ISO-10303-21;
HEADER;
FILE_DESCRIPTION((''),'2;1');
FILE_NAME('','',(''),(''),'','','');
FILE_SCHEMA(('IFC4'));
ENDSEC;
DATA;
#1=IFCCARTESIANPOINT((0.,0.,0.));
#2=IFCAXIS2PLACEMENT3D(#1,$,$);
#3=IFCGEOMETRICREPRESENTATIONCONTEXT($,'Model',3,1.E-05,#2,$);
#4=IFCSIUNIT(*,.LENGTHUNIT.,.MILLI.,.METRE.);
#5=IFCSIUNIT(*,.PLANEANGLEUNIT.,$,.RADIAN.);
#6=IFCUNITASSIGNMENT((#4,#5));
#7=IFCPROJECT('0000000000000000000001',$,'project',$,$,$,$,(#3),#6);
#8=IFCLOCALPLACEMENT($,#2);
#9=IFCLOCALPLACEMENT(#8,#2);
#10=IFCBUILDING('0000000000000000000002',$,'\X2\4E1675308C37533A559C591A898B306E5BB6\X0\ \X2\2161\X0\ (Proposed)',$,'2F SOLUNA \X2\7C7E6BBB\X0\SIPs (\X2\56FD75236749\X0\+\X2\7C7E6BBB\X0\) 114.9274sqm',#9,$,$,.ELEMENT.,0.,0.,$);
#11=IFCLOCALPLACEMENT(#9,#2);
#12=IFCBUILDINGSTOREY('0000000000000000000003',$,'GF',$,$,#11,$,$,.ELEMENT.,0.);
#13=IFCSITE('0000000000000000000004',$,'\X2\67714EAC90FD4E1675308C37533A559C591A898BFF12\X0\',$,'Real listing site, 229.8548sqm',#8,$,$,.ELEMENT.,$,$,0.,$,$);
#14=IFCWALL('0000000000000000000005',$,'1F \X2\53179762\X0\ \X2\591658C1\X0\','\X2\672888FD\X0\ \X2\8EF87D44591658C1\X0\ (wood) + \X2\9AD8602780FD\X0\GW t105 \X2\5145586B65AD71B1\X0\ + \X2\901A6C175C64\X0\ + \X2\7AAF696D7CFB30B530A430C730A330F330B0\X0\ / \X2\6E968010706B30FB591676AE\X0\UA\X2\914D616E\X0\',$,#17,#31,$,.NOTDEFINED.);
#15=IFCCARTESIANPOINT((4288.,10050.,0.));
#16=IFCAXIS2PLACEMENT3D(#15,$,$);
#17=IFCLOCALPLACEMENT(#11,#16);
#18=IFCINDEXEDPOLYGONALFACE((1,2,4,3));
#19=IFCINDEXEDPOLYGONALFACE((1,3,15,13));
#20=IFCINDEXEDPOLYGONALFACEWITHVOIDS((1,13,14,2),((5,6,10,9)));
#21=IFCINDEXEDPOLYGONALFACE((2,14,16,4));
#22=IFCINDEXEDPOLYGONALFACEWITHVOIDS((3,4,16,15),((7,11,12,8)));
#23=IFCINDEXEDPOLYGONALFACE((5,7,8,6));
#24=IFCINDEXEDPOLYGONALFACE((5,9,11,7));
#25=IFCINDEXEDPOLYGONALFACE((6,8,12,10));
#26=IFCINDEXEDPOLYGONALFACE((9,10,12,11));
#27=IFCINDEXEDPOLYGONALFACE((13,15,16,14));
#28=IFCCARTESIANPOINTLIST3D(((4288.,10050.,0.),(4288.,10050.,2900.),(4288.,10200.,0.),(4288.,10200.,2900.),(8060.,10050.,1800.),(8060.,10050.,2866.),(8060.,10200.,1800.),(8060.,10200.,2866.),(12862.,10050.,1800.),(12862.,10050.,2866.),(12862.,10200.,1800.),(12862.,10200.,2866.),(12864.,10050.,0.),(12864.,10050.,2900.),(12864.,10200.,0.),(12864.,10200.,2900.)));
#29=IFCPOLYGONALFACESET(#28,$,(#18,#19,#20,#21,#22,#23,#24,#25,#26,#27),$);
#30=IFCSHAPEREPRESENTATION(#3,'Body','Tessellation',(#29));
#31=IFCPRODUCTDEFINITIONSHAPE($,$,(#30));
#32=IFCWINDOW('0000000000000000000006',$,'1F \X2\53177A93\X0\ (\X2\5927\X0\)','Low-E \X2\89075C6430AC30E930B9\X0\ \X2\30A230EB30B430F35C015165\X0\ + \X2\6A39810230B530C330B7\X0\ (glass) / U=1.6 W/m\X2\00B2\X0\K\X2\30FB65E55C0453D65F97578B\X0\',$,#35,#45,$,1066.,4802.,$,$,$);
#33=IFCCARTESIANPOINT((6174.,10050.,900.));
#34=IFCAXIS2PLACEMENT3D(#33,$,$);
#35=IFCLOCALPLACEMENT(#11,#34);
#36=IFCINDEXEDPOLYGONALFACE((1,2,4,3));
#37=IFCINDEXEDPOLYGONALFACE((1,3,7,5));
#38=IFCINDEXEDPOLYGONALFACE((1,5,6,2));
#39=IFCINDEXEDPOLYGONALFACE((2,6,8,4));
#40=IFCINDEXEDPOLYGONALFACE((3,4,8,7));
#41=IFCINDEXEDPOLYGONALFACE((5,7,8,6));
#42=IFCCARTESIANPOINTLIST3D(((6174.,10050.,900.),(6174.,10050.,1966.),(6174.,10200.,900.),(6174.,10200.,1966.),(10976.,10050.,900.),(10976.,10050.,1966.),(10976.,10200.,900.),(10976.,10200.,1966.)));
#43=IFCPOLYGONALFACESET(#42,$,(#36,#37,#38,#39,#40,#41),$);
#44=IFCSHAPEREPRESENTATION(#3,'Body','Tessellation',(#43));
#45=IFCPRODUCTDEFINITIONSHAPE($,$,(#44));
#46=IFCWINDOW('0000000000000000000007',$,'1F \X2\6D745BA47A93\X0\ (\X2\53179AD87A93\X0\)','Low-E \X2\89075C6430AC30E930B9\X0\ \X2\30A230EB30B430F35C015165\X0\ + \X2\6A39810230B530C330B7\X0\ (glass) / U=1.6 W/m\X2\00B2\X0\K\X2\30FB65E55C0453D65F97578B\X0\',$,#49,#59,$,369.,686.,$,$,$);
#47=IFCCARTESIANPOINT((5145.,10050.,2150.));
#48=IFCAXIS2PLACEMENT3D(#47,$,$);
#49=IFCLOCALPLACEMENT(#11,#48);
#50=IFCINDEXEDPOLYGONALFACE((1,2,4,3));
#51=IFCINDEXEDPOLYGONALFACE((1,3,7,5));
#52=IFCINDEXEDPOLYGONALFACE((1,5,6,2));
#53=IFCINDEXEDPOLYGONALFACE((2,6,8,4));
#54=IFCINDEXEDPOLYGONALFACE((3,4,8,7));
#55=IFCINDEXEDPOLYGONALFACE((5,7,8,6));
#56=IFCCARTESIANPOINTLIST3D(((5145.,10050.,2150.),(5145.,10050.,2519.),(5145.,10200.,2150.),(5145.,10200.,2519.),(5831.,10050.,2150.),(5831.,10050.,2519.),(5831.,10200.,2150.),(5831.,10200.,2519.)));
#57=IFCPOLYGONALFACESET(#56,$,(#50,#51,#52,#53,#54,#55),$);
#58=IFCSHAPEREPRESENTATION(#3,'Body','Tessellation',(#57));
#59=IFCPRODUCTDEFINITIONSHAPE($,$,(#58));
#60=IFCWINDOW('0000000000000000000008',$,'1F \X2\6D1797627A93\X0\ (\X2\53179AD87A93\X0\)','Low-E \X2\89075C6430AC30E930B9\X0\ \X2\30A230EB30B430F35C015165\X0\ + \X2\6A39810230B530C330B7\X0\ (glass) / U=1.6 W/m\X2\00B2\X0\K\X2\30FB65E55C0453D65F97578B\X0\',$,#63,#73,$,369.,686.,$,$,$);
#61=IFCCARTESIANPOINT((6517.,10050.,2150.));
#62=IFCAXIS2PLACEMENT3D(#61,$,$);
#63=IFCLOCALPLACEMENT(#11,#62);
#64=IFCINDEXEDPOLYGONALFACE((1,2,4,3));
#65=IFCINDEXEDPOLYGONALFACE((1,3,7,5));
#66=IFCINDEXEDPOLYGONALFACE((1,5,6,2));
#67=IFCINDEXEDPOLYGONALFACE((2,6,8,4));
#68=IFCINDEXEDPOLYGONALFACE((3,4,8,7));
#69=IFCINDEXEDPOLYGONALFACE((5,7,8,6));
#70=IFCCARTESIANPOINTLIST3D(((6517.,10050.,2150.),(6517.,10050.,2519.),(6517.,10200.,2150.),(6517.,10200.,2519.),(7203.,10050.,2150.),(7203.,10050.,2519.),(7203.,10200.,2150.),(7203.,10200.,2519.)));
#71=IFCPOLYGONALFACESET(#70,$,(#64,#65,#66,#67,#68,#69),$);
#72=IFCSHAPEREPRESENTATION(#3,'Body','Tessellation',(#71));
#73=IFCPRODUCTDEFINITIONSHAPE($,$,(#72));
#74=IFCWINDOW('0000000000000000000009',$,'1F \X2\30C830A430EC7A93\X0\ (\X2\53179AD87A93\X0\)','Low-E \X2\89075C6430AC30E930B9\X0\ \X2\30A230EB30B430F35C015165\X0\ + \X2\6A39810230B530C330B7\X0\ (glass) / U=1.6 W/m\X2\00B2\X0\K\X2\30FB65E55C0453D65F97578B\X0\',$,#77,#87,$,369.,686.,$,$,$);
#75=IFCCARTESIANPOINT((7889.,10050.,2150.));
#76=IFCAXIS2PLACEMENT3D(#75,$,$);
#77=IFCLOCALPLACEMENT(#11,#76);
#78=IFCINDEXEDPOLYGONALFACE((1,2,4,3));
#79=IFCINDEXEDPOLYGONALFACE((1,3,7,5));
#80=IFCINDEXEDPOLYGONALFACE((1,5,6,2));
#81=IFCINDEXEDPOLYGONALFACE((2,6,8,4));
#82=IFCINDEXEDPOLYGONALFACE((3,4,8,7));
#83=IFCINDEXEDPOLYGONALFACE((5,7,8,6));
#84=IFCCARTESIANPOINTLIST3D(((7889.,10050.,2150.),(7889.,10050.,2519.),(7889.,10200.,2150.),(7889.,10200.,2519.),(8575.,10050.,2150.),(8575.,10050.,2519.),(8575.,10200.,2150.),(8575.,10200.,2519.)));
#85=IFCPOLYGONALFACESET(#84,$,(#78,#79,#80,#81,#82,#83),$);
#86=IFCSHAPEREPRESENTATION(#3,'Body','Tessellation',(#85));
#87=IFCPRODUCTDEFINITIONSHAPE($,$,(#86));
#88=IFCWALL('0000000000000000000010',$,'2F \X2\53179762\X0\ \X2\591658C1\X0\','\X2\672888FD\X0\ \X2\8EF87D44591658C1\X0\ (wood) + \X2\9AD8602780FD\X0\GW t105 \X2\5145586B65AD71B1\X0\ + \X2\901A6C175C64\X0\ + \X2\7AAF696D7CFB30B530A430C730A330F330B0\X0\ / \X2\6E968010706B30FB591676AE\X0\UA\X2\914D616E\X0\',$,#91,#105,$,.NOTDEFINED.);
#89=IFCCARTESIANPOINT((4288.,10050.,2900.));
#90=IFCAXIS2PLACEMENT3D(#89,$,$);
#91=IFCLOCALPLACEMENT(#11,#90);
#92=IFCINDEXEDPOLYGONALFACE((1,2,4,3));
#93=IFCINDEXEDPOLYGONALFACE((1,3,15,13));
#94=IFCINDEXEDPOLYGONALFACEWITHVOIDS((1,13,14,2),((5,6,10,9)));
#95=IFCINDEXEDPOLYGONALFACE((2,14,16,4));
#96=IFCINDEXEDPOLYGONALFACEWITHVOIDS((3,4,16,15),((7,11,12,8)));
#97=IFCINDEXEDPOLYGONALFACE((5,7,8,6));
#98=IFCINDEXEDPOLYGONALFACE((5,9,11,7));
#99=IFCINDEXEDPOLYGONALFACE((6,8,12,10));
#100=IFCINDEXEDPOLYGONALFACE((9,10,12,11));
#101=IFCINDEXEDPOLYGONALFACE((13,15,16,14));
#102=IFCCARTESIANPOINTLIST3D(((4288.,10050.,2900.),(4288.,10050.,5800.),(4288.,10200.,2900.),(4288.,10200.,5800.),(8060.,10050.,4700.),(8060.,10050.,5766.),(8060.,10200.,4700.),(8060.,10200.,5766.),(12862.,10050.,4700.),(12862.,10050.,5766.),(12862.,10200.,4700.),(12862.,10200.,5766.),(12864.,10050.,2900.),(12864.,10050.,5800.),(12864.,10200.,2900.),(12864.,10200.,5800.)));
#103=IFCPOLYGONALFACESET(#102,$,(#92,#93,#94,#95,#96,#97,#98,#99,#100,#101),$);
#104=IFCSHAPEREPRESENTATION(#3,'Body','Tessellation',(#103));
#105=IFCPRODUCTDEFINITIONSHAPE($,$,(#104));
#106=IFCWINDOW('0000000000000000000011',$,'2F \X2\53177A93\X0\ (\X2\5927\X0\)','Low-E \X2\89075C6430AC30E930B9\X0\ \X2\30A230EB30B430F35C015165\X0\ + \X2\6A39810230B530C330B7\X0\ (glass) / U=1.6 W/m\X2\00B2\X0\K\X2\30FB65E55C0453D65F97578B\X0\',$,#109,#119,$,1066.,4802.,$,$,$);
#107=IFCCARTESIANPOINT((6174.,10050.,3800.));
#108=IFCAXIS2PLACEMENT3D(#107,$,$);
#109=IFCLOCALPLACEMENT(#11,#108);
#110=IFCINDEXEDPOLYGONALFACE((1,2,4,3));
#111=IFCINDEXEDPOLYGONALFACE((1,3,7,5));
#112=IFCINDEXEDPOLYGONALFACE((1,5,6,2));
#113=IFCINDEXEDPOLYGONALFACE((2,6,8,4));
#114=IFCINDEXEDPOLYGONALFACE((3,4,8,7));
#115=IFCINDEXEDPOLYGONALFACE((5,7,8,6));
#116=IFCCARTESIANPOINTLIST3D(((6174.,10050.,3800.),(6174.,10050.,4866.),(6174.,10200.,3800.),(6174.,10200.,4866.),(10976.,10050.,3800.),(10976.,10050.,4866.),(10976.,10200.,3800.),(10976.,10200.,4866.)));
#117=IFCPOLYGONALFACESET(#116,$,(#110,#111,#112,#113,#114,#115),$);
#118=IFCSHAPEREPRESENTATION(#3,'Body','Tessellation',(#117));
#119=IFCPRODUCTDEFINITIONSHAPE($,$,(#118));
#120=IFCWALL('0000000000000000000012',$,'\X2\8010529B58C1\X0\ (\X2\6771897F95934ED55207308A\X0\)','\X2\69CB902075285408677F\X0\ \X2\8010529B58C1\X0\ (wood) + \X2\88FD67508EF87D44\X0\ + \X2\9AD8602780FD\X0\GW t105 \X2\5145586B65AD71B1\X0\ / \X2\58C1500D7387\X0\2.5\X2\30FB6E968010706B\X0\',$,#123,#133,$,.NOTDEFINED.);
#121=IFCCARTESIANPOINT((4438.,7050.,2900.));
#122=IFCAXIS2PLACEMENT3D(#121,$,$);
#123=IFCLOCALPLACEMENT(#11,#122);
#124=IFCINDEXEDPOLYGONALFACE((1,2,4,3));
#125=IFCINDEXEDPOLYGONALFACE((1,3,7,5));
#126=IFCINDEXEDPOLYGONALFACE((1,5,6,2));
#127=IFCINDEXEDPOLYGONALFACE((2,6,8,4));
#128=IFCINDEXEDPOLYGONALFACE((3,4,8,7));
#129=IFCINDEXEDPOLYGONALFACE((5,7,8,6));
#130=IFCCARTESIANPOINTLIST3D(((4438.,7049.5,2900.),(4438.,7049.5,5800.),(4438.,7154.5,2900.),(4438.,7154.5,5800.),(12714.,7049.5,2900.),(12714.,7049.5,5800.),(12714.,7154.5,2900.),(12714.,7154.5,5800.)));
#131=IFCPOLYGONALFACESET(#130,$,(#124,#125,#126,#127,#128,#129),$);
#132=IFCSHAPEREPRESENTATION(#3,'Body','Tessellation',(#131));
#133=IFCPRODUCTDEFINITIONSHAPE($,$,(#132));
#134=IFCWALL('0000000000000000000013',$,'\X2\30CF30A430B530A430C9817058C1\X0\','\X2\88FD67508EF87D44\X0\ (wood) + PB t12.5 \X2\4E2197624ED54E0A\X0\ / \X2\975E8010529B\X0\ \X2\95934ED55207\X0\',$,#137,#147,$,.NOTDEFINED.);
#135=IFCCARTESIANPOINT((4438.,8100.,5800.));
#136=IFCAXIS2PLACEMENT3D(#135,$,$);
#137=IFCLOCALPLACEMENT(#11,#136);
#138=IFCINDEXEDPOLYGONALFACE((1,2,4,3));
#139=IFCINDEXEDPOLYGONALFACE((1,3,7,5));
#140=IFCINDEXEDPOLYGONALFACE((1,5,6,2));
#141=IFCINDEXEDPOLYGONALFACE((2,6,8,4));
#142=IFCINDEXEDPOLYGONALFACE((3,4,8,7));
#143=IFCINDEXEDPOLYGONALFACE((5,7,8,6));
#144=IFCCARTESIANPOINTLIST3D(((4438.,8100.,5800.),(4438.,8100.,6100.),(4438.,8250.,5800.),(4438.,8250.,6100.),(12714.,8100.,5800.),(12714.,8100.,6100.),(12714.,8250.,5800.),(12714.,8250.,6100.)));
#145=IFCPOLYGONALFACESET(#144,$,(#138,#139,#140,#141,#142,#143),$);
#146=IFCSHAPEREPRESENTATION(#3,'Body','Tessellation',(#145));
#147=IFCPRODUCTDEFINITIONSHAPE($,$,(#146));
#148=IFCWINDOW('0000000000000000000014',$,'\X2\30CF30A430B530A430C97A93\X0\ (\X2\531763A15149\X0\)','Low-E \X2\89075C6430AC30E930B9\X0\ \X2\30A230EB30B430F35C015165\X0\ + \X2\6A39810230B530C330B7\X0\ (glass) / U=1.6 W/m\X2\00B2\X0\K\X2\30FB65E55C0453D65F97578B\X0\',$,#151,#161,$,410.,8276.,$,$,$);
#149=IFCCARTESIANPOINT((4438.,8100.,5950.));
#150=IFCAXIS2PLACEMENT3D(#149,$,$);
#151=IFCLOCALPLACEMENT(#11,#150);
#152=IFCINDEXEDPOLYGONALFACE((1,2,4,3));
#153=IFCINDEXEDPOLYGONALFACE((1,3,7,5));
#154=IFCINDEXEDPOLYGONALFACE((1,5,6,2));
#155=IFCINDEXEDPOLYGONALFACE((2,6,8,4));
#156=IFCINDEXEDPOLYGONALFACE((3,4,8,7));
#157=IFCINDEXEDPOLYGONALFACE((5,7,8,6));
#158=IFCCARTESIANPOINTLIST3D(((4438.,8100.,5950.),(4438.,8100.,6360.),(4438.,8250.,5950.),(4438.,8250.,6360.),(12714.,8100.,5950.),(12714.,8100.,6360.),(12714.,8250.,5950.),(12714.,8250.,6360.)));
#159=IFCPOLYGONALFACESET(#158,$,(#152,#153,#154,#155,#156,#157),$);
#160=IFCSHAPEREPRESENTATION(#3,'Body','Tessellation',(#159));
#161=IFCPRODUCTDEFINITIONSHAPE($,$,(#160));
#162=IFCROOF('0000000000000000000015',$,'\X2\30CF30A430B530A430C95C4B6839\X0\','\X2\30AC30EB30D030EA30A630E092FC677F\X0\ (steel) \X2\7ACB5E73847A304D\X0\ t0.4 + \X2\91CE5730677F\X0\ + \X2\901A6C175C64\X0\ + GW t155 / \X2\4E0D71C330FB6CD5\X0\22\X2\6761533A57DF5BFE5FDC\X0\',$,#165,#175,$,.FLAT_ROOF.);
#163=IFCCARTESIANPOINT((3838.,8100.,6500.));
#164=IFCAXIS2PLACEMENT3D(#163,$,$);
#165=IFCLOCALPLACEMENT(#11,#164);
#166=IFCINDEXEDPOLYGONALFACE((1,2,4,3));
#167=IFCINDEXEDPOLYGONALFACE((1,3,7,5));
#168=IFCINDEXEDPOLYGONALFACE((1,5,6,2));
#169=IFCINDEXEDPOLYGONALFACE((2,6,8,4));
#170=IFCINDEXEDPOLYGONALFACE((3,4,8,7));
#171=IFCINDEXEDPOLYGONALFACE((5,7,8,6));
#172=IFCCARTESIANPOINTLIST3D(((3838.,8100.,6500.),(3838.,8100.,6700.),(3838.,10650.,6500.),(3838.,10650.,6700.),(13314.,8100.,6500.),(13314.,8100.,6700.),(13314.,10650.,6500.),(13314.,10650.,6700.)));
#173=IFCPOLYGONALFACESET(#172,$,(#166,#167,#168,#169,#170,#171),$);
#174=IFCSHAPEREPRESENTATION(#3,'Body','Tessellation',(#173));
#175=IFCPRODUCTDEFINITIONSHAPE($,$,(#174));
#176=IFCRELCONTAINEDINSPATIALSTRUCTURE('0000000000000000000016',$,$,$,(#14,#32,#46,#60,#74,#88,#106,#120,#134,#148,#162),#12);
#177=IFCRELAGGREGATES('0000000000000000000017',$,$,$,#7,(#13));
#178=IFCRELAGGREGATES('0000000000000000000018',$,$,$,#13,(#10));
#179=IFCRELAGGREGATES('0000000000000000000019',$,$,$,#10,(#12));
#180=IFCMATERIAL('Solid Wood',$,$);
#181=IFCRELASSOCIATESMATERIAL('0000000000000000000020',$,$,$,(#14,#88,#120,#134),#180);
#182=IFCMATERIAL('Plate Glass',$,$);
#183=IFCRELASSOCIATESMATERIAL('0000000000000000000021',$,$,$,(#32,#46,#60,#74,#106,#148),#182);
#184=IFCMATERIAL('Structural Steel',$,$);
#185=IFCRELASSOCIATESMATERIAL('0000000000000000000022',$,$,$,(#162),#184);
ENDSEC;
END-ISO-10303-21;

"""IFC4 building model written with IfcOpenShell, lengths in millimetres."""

from ifc_helpers import new_model, si_unit, frame, frame_2d, origin, place, context, project, spatial, rectangle, extrude, material, element, fill, save


model = new_model("IFC4")

# Units and contexts
model_context = context("Model", 3, precision=1e-05, world=origin())
ifc_project = project(units=[si_unit("LENGTHUNIT", "METRE", prefix="MILLI"), si_unit("PLANEANGLEUNIT", "RADIAN")], contexts=[model_context])

# Site, building, storey
site_placement = place(None, origin())
site = spatial("IfcSite", under=ifc_project, at=site_placement, Name="東京都世田谷区喜多見２", ObjectType="Real listing site, 229.8548sqm", CompositionType="ELEMENT", RefElevation=0.0)
building_placement = place(site_placement, origin())
building = spatial("IfcBuilding", under=site, at=building_placement, Name="世田谷区喜多見の家 Ⅱ (Proposed)", ObjectType="2F SOLUNA 籾殻SIPs (国産杉+籾殻) 114.9274sqm", CompositionType="ELEMENT", ElevationOfRefHeight=0.0, ElevationOfTerrain=0.0)
storey_placement = place(building_placement, origin())
storey = spatial("IfcBuildingStorey", under=building, at=storey_placement, Name="GF", CompositionType="ELEMENT", Elevation=0.0)

# Wall, openings, windows
ifc_material_1 = material(Name="Solid Wood")
wall_1_placement = place(storey_placement, frame((4288.0, 10050.0, 0.0)))
wall_1 = element("IfcWall", 1, at=wall_1_placement, inside=storey, material=ifc_material_1, Name="1F 北面 外壁", Description="木製 軸組外壁 (wood) + 高性能GW t105 充填断熱 + 通気層 + 窯業系サイディング / 準耐火・外皮UA配慮", PredefinedType="NOTDEFINED", context=model_context, shape_type="SweptSolid", body=[
    extrude(rectangle(XDim=8576.0, YDim=150.0, at=frame_2d((4288.0, 75.0))), frame((4288.0, 10050.0, 0.0)), (0.0, 0.0, 1.0), 2900.0),
])
opening_1_placement = place(storey_placement, frame((6174.0, 10050.0, 900.0)))
opening_1 = element("IfcOpeningElement", 2, at=opening_1_placement, cuts=wall_1, PredefinedType="NOTDEFINED", context=model_context, shape_type="SweptSolid", body=[
    extrude(rectangle(XDim=4802.0, YDim=150.0, at=frame_2d((2401.0, 75.0))), frame((6174.0, 10050.0, 900.0)), (0.0, 0.0, 1.0), 1066.0),
])
opening_2_placement = place(storey_placement, frame((5145.0, 10050.0, 2150.0)))
opening_2 = element("IfcOpeningElement", 3, at=opening_2_placement, cuts=wall_1, PredefinedType="NOTDEFINED", context=model_context, shape_type="SweptSolid", body=[
    extrude(rectangle(XDim=686.0, YDim=150.0, at=frame_2d((343.0, 75.0))), frame((5145.0, 10050.0, 2150.0)), (0.0, 0.0, 1.0), 369.0),
])
opening_3_placement = place(storey_placement, frame((6517.0, 10050.0, 2150.0)))
opening_3 = element("IfcOpeningElement", 4, at=opening_3_placement, cuts=wall_1, PredefinedType="NOTDEFINED", context=model_context, shape_type="SweptSolid", body=[
    extrude(rectangle(XDim=686.0, YDim=150.0, at=frame_2d((343.0, 75.0))), frame((6517.0, 10050.0, 2150.0)), (0.0, 0.0, 1.0), 369.0),
])
opening_4_placement = place(storey_placement, frame((7889.0, 10050.0, 2150.0)))
opening_4 = element("IfcOpeningElement", 5, at=opening_4_placement, cuts=wall_1, PredefinedType="NOTDEFINED", context=model_context, shape_type="SweptSolid", body=[
    extrude(rectangle(XDim=686.0, YDim=150.0, at=frame_2d((343.0, 75.0))), frame((7889.0, 10050.0, 2150.0)), (0.0, 0.0, 1.0), 369.0),
])
ifc_material_2 = material(Name="Plate Glass")
window_1_placement = place(storey_placement, frame((6174.0, 10050.0, 900.0)))
window_1 = element("IfcWindow", 6, at=window_1_placement, inside=storey, material=ifc_material_2, Name="1F 北窓 (大)", Description="Low-E 複層ガラス アルゴン封入 + 樹脂サッシ (glass) / U=1.6 W/m²K・日射取得型", OverallHeight=1066.0, OverallWidth=4802.0, context=model_context, shape_type="SweptSolid", body=[
    extrude(rectangle(XDim=4802.0, YDim=150.0, at=frame_2d((2401.0, 75.0))), frame((6174.0, 10050.0, 900.0)), (0.0, 0.0, 1.0), 1066.0),
])
fill(opening_1, window_1)
window_2_placement = place(storey_placement, frame((5145.0, 10050.0, 2150.0)))
window_2 = element("IfcWindow", 7, at=window_2_placement, inside=storey, material=ifc_material_2, Name="1F 浴室窓 (北高窓)", Description="Low-E 複層ガラス アルゴン封入 + 樹脂サッシ (glass) / U=1.6 W/m²K・日射取得型", OverallHeight=369.0, OverallWidth=686.0, context=model_context, shape_type="SweptSolid", body=[
    extrude(rectangle(XDim=686.0, YDim=150.0, at=frame_2d((343.0, 75.0))), frame((5145.0, 10050.0, 2150.0)), (0.0, 0.0, 1.0), 369.0),
])
fill(opening_2, window_2)
window_3_placement = place(storey_placement, frame((6517.0, 10050.0, 2150.0)))
window_3 = element("IfcWindow", 8, at=window_3_placement, inside=storey, material=ifc_material_2, Name="1F 洗面窓 (北高窓)", Description="Low-E 複層ガラス アルゴン封入 + 樹脂サッシ (glass) / U=1.6 W/m²K・日射取得型", OverallHeight=369.0, OverallWidth=686.0, context=model_context, shape_type="SweptSolid", body=[
    extrude(rectangle(XDim=686.0, YDim=150.0, at=frame_2d((343.0, 75.0))), frame((6517.0, 10050.0, 2150.0)), (0.0, 0.0, 1.0), 369.0),
])
fill(opening_3, window_3)
window_4_placement = place(storey_placement, frame((7889.0, 10050.0, 2150.0)))
window_4 = element("IfcWindow", 9, at=window_4_placement, inside=storey, material=ifc_material_2, Name="1F トイレ窓 (北高窓)", Description="Low-E 複層ガラス アルゴン封入 + 樹脂サッシ (glass) / U=1.6 W/m²K・日射取得型", OverallHeight=369.0, OverallWidth=686.0, context=model_context, shape_type="SweptSolid", body=[
    extrude(rectangle(XDim=686.0, YDim=150.0, at=frame_2d((343.0, 75.0))), frame((7889.0, 10050.0, 2150.0)), (0.0, 0.0, 1.0), 369.0),
])
fill(opening_4, window_4)

# Wall, opening, window
wall_2_placement = place(storey_placement, frame((4288.0, 10050.0, 2900.0)))
wall_2 = element("IfcWall", 10, at=wall_2_placement, inside=storey, material=ifc_material_1, Name="2F 北面 外壁", Description="木製 軸組外壁 (wood) + 高性能GW t105 充填断熱 + 通気層 + 窯業系サイディング / 準耐火・外皮UA配慮", PredefinedType="NOTDEFINED", context=model_context, shape_type="SweptSolid", body=[
    extrude(rectangle(XDim=8576.0, YDim=150.0, at=frame_2d((4288.0, 75.0))), frame((4288.0, 10050.0, 2900.0)), (0.0, 0.0, 1.0), 2900.0),
])
opening_5_placement = place(storey_placement, frame((6174.0, 10050.0, 3800.0)))
opening_5 = element("IfcOpeningElement", 11, at=opening_5_placement, cuts=wall_2, PredefinedType="NOTDEFINED", context=model_context, shape_type="SweptSolid", body=[
    extrude(rectangle(XDim=4802.0, YDim=150.0, at=frame_2d((2401.0, 75.0))), frame((6174.0, 10050.0, 3800.0)), (0.0, 0.0, 1.0), 1066.0),
])
window_5_placement = place(storey_placement, frame((6174.0, 10050.0, 3800.0)))
window_5 = element("IfcWindow", 12, at=window_5_placement, inside=storey, material=ifc_material_2, Name="2F 北窓 (大)", Description="Low-E 複層ガラス アルゴン封入 + 樹脂サッシ (glass) / U=1.6 W/m²K・日射取得型", OverallHeight=1066.0, OverallWidth=4802.0, context=model_context, shape_type="SweptSolid", body=[
    extrude(rectangle(XDim=4802.0, YDim=150.0, at=frame_2d((2401.0, 75.0))), frame((6174.0, 10050.0, 3800.0)), (0.0, 0.0, 1.0), 1066.0),
])
fill(opening_5, window_5)

# Wall
wall_3_placement = place(storey_placement, frame((4438.0, 7050.0, 2900.0)))
element("IfcWall", 13, at=wall_3_placement, inside=storey, material=ifc_material_1, Name="耐力壁 (東西間仕切り)", Description="構造用合板 耐力壁 (wood) + 製材軸組 + 高性能GW t105 充填断熱 / 壁倍率2.5・準耐火", PredefinedType="NOTDEFINED", context=model_context, shape_type="SweptSolid", body=[
    extrude(rectangle(XDim=8276.0, YDim=105.0, at=frame_2d((4138.0, 52.0))), frame((4438.0, 7050.0, 2900.0)), (0.0, 0.0, 1.0), 2900.0),
])

# Wall, opening, window
wall_4_placement = place(storey_placement, frame((4438.0, 8100.0, 5800.0)))
wall_4 = element("IfcWall", 14, at=wall_4_placement, inside=storey, material=ifc_material_1, Name="ハイサイド腰壁", Description="製材軸組 (wood) + PB t12.5 両面仕上 / 非耐力 間仕切", PredefinedType="NOTDEFINED", context=model_context, shape_type="SweptSolid", body=[
    extrude(rectangle(XDim=8276.0, YDim=150.0, at=frame_2d((4138.0, 75.0))), frame((4438.0, 8100.0, 5800.0)), (0.0, 0.0, 1.0), 700.0),
])
opening_6_placement = place(storey_placement, frame((4438.0, 8100.0, 5950.0)))
opening_6 = element("IfcOpeningElement", 15, at=opening_6_placement, cuts=wall_4, PredefinedType="NOTDEFINED", context=model_context, shape_type="SweptSolid", body=[
    extrude(rectangle(XDim=8276.0, YDim=150.0, at=frame_2d((4138.0, 75.0))), frame((4438.0, 8100.0, 5950.0)), (0.0, 0.0, 1.0), 410.0),
])
window_6_placement = place(storey_placement, frame((4438.0, 8100.0, 5950.0)))
window_6 = element("IfcWindow", 16, at=window_6_placement, inside=storey, material=ifc_material_2, Name="ハイサイド窓 (北採光)", Description="Low-E 複層ガラス アルゴン封入 + 樹脂サッシ (glass) / U=1.6 W/m²K・日射取得型", OverallHeight=410.0, OverallWidth=8276.0, context=model_context, shape_type="SweptSolid", body=[
    extrude(rectangle(XDim=8276.0, YDim=150.0, at=frame_2d((4138.0, 75.0))), frame((4438.0, 8100.0, 5950.0)), (0.0, 0.0, 1.0), 410.0),
])
fill(opening_6, window_6)

# Roof
ifc_material_3 = material(Name="Structural Steel")
roof_placement = place(storey_placement, frame((3838.0, 8100.0, 6500.0)))
element("IfcRoof", 17, at=roof_placement, inside=storey, material=ifc_material_3, Name="ハイサイド屋根", Description="ガルバリウム鋼板 (steel) 立平葺き t0.4 + 野地板 + 通気層 + GW t155 / 不燃・法22条区域対応", PredefinedType="FLAT_ROOF", context=model_context, shape_type="SweptSolid", body=[
    extrude(rectangle(XDim=9476.0, YDim=2550.0, at=frame_2d((4738.0, 1275.0))), frame((3838.0, 8100.0, 6500.0)), (0.0, 0.0, 1.0), 200.0),
])

save(model, "model.ifc")
